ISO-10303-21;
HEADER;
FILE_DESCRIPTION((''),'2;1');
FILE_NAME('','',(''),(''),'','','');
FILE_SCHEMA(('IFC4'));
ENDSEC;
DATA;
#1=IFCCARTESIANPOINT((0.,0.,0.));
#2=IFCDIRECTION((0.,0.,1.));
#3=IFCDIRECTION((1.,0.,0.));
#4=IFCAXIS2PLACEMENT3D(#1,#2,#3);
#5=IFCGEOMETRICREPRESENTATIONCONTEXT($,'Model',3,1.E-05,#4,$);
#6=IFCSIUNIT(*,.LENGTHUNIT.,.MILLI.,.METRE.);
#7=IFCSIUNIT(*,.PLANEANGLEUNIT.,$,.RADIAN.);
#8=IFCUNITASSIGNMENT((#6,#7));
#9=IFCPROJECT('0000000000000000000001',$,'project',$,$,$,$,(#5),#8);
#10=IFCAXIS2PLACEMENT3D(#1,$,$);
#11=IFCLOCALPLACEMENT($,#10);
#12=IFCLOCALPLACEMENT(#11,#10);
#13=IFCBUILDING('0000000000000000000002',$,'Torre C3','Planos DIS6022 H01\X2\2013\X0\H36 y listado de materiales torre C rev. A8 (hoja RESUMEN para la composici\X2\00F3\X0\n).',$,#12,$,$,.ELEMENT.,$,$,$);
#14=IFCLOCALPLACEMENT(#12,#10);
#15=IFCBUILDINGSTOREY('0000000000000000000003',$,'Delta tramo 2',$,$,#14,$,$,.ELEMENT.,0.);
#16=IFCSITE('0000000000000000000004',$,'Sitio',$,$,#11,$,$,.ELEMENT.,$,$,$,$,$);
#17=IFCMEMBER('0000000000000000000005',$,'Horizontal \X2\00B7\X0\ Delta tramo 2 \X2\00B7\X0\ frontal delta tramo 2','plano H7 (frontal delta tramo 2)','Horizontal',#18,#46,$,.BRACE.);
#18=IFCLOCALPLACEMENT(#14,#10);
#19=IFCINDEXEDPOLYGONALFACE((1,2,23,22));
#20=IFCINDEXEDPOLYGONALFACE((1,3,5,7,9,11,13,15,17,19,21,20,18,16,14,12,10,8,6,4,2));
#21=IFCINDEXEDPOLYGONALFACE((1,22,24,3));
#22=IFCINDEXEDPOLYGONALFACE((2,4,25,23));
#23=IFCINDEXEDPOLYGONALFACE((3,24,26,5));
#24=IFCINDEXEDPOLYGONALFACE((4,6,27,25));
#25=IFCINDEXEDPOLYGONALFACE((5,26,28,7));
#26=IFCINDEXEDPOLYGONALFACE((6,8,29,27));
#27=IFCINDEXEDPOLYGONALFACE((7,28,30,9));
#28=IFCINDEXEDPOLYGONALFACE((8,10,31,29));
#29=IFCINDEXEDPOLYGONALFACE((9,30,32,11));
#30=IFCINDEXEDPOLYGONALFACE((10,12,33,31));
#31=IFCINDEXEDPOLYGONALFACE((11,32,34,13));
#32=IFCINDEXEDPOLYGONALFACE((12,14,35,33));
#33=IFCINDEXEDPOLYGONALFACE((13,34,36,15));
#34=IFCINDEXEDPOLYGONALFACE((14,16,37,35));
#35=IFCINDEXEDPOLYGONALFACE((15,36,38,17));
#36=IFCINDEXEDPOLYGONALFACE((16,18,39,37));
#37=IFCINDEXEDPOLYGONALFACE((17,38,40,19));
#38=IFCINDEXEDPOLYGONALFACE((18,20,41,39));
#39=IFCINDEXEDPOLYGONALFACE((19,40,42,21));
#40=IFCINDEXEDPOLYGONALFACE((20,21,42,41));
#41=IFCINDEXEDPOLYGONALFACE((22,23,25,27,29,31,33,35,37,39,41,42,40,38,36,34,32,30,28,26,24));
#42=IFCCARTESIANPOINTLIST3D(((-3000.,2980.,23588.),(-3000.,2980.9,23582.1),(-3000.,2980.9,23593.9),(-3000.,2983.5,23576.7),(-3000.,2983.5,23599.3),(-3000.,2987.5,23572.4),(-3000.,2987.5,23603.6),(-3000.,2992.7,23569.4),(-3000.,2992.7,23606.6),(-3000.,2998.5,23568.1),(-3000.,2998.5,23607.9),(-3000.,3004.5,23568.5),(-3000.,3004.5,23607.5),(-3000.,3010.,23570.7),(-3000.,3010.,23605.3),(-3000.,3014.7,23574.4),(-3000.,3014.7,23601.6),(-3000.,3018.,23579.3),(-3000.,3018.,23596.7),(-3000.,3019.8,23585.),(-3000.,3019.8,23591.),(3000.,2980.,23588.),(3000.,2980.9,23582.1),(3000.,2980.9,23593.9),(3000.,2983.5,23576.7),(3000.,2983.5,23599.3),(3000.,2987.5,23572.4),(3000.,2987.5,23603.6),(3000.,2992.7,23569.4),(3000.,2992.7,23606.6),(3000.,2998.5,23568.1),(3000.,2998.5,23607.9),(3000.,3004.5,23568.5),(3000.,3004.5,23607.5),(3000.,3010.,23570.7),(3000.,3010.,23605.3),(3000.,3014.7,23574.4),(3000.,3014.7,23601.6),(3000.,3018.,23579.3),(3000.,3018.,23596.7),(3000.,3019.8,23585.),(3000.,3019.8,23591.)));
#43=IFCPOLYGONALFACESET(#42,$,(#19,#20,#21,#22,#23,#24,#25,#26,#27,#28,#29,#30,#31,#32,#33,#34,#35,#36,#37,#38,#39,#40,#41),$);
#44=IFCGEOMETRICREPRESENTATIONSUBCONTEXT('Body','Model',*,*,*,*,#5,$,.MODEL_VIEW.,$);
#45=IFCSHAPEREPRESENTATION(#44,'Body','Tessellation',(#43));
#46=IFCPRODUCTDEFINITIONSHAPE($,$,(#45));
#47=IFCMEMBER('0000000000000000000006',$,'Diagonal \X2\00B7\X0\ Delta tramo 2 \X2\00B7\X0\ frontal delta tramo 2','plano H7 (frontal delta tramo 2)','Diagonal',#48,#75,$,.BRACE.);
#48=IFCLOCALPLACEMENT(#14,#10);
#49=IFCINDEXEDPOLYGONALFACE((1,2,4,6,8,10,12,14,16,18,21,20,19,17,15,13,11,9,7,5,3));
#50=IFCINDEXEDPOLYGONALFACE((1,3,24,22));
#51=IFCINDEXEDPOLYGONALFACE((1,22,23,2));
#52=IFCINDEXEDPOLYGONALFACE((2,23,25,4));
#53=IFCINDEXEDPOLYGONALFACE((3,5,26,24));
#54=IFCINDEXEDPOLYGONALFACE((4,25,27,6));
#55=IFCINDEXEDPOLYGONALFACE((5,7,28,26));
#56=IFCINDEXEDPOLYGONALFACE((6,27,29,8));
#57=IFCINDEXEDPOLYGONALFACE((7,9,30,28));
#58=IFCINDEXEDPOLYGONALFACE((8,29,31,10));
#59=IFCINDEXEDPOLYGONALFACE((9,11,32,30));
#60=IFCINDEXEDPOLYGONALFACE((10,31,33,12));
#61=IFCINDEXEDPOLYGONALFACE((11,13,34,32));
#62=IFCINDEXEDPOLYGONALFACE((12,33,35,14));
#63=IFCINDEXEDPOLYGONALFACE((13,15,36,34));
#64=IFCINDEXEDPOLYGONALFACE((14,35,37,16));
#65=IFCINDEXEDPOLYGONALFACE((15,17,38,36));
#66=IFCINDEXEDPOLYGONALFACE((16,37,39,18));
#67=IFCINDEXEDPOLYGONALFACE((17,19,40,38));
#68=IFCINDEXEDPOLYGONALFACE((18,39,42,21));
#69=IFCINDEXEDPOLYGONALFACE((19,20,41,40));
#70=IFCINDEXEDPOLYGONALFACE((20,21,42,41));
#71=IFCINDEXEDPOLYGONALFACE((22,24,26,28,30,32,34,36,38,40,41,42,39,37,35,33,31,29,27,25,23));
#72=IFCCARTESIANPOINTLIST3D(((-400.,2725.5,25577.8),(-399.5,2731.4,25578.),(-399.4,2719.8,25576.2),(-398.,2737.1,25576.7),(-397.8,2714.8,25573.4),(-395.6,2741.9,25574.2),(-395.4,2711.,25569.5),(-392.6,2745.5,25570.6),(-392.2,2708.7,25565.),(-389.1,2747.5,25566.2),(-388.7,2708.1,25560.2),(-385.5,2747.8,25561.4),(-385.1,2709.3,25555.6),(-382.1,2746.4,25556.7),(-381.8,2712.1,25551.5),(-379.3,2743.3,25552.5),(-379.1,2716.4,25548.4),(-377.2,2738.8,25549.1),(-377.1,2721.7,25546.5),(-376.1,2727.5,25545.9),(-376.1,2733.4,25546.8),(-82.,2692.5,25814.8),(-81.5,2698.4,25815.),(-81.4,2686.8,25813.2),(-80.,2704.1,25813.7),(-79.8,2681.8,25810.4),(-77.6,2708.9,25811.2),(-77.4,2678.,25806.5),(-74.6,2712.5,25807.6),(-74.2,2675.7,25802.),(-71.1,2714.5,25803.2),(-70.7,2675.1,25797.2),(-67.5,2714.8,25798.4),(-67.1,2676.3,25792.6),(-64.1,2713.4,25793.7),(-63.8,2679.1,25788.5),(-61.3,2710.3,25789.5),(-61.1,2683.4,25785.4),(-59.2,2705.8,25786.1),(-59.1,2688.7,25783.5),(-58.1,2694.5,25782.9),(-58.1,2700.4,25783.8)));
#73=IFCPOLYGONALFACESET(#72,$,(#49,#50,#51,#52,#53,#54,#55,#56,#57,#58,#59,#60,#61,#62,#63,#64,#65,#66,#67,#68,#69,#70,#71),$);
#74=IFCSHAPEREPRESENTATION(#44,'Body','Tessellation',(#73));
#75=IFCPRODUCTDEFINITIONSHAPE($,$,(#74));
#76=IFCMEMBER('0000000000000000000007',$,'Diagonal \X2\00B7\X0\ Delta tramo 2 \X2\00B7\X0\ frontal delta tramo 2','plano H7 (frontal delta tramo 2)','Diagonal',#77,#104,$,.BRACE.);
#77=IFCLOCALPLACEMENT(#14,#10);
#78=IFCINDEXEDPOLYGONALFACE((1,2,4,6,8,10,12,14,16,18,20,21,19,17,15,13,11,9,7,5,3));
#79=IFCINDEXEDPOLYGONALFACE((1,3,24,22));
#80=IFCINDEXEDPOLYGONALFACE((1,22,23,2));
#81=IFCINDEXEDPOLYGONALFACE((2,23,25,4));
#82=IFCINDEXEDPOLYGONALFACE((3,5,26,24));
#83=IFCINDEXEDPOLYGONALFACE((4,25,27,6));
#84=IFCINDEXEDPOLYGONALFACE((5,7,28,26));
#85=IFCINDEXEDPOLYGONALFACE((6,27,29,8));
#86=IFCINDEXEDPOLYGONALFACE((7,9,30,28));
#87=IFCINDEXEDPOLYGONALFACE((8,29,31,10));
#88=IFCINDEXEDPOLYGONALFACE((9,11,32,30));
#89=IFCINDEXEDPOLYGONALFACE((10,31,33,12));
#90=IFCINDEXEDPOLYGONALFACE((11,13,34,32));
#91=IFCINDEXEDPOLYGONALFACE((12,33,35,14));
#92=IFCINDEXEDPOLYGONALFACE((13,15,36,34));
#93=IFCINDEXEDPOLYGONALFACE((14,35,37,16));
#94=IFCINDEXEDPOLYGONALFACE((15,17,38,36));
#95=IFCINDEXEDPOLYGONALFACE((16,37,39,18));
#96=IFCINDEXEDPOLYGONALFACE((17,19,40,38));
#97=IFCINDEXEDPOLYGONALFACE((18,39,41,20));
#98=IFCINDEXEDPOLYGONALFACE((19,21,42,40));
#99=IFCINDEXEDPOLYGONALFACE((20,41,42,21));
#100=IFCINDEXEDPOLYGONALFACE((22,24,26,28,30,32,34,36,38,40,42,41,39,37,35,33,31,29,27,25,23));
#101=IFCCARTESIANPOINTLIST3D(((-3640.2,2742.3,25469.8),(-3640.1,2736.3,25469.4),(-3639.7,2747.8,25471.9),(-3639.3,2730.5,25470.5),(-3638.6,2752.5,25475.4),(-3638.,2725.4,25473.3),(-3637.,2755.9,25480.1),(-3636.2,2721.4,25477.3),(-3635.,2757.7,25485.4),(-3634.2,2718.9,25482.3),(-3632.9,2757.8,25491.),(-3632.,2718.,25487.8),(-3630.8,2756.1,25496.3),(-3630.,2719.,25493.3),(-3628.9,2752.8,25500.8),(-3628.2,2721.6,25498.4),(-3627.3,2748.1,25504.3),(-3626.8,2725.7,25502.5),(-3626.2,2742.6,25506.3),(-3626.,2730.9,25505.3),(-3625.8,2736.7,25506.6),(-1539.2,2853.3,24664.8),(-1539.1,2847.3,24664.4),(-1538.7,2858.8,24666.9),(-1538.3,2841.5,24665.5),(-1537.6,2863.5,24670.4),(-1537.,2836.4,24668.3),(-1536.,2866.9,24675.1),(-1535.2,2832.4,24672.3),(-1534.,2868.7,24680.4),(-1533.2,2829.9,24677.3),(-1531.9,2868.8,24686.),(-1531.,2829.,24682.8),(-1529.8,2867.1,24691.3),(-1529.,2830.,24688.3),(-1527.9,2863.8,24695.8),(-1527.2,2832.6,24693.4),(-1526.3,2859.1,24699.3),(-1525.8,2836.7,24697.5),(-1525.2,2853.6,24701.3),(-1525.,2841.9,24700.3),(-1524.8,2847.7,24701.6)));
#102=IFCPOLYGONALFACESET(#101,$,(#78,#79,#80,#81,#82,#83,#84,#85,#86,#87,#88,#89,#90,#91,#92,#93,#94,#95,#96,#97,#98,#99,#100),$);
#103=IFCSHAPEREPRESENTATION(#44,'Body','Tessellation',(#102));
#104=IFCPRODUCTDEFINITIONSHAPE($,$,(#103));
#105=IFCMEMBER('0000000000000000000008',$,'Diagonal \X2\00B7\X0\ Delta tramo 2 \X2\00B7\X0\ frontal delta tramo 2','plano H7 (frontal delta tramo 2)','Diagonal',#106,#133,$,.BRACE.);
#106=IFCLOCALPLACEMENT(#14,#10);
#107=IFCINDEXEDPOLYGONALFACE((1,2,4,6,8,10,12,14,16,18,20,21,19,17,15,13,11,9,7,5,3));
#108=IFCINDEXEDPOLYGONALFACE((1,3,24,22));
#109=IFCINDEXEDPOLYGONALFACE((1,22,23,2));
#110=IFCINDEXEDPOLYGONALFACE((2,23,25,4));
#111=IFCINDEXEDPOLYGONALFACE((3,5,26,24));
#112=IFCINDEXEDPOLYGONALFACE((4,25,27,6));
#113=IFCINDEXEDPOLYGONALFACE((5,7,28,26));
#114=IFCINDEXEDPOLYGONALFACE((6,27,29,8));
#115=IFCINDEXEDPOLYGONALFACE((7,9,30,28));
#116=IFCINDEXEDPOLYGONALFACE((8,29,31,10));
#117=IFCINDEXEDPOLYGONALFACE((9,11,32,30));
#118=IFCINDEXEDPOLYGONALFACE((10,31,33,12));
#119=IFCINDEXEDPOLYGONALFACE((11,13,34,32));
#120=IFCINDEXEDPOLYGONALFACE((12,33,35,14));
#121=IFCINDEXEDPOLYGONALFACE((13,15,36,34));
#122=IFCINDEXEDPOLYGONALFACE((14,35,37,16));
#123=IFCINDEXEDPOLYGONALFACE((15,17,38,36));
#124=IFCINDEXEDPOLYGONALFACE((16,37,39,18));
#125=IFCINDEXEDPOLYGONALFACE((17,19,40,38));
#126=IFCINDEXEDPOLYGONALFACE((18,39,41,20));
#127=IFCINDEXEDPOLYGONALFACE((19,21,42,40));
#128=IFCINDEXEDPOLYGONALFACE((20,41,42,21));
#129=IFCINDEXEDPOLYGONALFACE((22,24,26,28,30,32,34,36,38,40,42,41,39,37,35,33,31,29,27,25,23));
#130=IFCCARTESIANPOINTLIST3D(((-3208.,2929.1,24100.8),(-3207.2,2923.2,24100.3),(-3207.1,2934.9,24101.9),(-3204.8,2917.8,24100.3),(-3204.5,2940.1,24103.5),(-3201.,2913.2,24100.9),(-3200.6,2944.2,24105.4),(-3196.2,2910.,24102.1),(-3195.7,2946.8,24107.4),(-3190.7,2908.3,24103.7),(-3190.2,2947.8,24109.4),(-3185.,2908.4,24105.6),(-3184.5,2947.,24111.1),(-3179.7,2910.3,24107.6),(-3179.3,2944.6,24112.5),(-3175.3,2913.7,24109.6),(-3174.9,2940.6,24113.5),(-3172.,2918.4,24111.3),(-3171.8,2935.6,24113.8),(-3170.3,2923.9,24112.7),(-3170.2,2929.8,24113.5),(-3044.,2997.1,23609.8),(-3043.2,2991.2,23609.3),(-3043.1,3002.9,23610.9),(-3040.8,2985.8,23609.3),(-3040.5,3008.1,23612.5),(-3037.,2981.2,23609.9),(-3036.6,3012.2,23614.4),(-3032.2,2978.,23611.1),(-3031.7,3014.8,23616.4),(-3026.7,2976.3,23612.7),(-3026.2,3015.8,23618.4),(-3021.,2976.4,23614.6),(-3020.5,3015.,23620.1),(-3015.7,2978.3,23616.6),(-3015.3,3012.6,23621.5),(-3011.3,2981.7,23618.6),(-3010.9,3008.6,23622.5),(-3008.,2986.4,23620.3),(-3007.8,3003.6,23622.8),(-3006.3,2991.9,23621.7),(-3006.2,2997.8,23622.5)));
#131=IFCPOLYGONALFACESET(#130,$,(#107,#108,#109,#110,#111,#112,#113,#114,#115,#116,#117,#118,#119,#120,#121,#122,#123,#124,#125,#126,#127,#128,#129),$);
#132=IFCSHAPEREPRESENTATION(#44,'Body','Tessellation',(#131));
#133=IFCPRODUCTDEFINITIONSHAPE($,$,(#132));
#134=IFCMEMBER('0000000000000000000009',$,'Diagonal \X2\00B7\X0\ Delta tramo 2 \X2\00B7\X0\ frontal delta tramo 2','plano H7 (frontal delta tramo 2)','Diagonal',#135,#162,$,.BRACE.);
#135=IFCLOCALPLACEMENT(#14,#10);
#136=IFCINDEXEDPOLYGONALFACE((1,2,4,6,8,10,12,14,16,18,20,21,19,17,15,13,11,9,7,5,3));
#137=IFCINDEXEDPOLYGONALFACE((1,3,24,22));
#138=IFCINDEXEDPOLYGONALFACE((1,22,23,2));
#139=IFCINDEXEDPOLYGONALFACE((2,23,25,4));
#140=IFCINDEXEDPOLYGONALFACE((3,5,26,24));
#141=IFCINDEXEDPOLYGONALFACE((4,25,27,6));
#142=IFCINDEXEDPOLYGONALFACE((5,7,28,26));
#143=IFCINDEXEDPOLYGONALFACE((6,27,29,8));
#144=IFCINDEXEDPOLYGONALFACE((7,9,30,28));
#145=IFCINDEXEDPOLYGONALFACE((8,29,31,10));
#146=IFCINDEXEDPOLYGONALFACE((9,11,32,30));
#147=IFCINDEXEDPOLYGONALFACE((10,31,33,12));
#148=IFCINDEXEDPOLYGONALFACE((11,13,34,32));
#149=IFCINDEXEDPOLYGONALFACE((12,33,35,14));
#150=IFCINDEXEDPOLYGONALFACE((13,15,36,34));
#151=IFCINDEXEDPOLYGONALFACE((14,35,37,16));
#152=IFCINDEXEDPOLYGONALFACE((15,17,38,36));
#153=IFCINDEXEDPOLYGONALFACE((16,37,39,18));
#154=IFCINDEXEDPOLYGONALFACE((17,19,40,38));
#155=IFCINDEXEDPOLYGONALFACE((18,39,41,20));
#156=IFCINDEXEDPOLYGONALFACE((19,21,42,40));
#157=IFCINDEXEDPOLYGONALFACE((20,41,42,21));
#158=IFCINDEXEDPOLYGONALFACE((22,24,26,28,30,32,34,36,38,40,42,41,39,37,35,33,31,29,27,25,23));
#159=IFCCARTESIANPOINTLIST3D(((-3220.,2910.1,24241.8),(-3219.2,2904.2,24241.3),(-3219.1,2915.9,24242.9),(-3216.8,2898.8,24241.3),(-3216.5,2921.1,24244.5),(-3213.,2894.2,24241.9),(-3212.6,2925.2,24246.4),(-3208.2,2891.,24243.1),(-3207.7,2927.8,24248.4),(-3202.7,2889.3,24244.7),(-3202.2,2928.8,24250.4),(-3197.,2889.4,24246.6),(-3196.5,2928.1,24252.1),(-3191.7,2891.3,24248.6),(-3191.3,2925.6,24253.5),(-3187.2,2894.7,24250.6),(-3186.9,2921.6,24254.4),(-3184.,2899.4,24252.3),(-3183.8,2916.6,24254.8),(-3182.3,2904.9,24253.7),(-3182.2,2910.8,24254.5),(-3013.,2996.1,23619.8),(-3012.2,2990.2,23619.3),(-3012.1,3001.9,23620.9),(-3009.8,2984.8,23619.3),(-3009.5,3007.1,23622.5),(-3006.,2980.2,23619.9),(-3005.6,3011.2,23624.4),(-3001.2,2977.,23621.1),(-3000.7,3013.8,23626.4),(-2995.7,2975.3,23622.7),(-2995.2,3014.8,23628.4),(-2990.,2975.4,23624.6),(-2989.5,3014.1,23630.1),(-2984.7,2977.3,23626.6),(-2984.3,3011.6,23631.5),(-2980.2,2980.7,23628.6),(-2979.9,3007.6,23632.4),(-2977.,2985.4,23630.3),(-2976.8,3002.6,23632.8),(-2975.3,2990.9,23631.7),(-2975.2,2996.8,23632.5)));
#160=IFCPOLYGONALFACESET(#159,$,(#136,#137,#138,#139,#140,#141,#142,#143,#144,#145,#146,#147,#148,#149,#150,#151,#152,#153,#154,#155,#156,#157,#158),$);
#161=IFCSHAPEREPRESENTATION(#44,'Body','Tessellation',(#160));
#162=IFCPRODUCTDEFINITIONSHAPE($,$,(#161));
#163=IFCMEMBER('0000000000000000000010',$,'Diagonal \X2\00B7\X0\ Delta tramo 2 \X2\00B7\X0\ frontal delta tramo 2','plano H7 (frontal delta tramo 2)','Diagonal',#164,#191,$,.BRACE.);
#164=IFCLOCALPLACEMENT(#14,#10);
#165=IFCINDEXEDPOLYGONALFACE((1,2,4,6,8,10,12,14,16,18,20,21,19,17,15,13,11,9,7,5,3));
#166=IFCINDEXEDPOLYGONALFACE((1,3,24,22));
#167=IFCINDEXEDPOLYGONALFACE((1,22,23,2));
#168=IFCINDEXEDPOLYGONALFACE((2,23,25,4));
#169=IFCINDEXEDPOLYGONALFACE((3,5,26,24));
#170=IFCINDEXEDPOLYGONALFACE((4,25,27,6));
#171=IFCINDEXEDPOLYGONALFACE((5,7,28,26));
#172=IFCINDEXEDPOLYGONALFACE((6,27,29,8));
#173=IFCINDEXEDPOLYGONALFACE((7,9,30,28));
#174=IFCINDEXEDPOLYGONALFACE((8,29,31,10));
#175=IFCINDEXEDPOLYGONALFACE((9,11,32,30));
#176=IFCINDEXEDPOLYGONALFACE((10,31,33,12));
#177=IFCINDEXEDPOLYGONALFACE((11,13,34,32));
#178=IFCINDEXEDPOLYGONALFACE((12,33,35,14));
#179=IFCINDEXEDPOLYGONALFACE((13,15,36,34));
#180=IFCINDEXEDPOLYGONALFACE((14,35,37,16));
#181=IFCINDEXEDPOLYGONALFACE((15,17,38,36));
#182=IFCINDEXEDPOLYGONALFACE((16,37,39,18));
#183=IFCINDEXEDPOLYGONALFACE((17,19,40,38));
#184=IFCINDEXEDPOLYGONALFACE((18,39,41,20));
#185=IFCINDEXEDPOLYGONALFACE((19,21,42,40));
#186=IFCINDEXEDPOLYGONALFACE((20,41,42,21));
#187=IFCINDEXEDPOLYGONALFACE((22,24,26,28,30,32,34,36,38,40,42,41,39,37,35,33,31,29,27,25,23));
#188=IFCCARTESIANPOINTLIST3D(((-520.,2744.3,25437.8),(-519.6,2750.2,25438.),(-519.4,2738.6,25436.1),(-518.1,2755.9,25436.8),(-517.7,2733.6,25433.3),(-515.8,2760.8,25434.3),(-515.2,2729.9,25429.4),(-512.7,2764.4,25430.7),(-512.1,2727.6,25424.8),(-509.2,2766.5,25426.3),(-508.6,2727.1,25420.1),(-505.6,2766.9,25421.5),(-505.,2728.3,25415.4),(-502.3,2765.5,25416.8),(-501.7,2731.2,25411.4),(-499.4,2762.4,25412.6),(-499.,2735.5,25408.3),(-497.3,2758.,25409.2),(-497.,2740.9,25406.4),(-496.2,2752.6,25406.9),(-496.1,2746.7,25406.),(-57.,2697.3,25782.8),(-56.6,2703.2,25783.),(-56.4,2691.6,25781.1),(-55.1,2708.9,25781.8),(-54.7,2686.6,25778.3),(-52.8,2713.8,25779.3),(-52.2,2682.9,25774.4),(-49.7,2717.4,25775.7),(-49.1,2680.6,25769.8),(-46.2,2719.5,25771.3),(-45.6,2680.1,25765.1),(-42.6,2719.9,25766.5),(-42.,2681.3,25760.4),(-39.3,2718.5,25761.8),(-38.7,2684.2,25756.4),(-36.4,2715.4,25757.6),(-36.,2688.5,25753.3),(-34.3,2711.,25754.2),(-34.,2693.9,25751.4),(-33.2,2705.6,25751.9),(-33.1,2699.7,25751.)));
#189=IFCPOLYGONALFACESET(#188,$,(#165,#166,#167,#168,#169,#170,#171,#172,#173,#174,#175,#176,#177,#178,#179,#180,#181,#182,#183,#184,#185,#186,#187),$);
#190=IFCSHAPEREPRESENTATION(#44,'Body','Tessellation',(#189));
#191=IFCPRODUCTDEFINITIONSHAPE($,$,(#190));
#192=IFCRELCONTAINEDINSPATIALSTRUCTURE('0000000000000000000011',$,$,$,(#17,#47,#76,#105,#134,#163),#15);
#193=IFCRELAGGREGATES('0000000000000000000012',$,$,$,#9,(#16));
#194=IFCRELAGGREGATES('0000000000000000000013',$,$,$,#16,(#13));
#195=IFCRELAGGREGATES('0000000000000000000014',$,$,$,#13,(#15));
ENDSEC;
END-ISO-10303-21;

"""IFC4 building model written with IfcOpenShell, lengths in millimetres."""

from ifc_helpers import new_model, si_unit, frame, origin, origin_with_axes, place, context, subcontext, project, spatial, circle, extrude, element, save


model = new_model("IFC4")

# Units and contexts
model_context = context("Model", 3, precision=1e-05, world=origin_with_axes())
body_context = subcontext(model_context, "Body", "Model", "MODEL_VIEW")
ifc_project = project(units=[si_unit("LENGTHUNIT", "METRE", prefix="MILLI"), si_unit("PLANEANGLEUNIT", "RADIAN")], contexts=[model_context])

# Site, building, storey
site_placement = place(None, origin())
site = spatial("IfcSite", under=ifc_project, at=site_placement, Name="Sitio", CompositionType="ELEMENT")
building_placement = place(site_placement, origin())
building = spatial("IfcBuilding", under=site, at=building_placement, Name="Torre C3", Description="Planos DIS6022 H01–H36 y listado de materiales torre C rev. A8 (hoja RESUMEN para la composición).", CompositionType="ELEMENT")
storey_placement = place(building_placement, origin())
storey = spatial("IfcBuildingStorey", under=building, at=storey_placement, Name="Delta tramo 2", CompositionType="ELEMENT", Elevation=0.0)

# Members
member_1_placement = place(storey_placement, frame((-3000.0, 3000.0, 23588.0), z_axis=(1.0, 0.0, 0.0), x_axis=(0.0, -1.0, 0.0)))
element("IfcMember", 1, at=member_1_placement, inside=storey, Name="Horizontal · Delta tramo 2 · frontal delta tramo 2", Description="plano H7 (frontal delta tramo 2)", ObjectType="Horizontal", PredefinedType="BRACE", context=body_context, shape_type="SweptSolid", body=[
    extrude(circle(Radius=20.0), None, (0.0, 0.0, 1.0), 6000.0),
])
member_2_placement = place(storey_placement, frame((-70.0, 2695.0, 25799.0), z_axis=(-0.79905, 0.08292, -0.595519), x_axis=(-0.036005, -0.995266, -0.09027)))
element("IfcMember", 2, at=member_2_placement, inside=storey, Name="Diagonal · Delta tramo 2 · frontal delta tramo 2", Description="plano H7 (frontal delta tramo 2)", ObjectType="Diagonal", PredefinedType="BRACE", context=body_context, shape_type="SweptSolid", body=[
    extrude(circle(Radius=20.0), None, (0.0, 0.0, 1.0), 398.0),
])
member_3_placement = place(storey_placement, frame((-1532.0, 2849.0, 24683.0), z_axis=(-0.932669, -0.049275, 0.357353), x_axis=(0.152168, -0.951918, 0.26589)))
element("IfcMember", 3, at=member_3_placement, inside=storey, Name="Diagonal · Delta tramo 2 · frontal delta tramo 2", Description="plano H7 (frontal delta tramo 2)", ObjectType="Diagonal", PredefinedType="BRACE", context=body_context, shape_type="SweptSolid", body=[
    extrude(circle(Radius=20.0), None, (0.0, 0.0, 1.0), 2252.7),
])
member_4_placement = place(storey_placement, frame((-3025.0, 2996.0, 23616.0), z_axis=(-0.314109, -0.13024, 0.940411), x_axis=(0.687135, -0.714708, 0.130529)))
element("IfcMember", 4, at=member_4_placement, inside=storey, Name="Diagonal · Delta tramo 2 · frontal delta tramo 2", Description="plano H7 (frontal delta tramo 2)", ObjectType="Diagonal", PredefinedType="BRACE", context=body_context, shape_type="SweptSolid", body=[
    extrude(circle(Radius=20.0), None, (0.0, 0.0, 1.0), 522.1),
])
member_5_placement = place(storey_placement, frame((-2994.0, 2995.0, 23626.0), z_axis=(-0.313087, -0.130075, 0.940775), x_axis=(0.687514, -0.714436, 0.130023)))
element("IfcMember", 5, at=member_5_placement, inside=storey, Name="Diagonal · Delta tramo 2 · frontal delta tramo 2", Description="plano H7 (frontal delta tramo 2)", ObjectType="Diagonal", PredefinedType="BRACE", context=body_context, shape_type="SweptSolid", body=[
    extrude(circle(Radius=20.0), None, (0.0, 0.0, 1.0), 661.2),
])
member_6_placement = place(storey_placement, frame((-45.0, 2700.0, 25767.0), z_axis=(-0.799223, 0.081131, -0.595533), x_axis=(-0.028395, -0.994838, -0.097421)))
element("IfcMember", 6, at=member_6_placement, inside=storey, Name="Diagonal · Delta tramo 2 · frontal delta tramo 2", Description="plano H7 (frontal delta tramo 2)", ObjectType="Diagonal", PredefinedType="BRACE", context=body_context, shape_type="SweptSolid", body=[
    extrude(circle(Radius=20.0), None, (0.0, 0.0, 1.0), 579.3),
])

save(model, "model.ifc")
